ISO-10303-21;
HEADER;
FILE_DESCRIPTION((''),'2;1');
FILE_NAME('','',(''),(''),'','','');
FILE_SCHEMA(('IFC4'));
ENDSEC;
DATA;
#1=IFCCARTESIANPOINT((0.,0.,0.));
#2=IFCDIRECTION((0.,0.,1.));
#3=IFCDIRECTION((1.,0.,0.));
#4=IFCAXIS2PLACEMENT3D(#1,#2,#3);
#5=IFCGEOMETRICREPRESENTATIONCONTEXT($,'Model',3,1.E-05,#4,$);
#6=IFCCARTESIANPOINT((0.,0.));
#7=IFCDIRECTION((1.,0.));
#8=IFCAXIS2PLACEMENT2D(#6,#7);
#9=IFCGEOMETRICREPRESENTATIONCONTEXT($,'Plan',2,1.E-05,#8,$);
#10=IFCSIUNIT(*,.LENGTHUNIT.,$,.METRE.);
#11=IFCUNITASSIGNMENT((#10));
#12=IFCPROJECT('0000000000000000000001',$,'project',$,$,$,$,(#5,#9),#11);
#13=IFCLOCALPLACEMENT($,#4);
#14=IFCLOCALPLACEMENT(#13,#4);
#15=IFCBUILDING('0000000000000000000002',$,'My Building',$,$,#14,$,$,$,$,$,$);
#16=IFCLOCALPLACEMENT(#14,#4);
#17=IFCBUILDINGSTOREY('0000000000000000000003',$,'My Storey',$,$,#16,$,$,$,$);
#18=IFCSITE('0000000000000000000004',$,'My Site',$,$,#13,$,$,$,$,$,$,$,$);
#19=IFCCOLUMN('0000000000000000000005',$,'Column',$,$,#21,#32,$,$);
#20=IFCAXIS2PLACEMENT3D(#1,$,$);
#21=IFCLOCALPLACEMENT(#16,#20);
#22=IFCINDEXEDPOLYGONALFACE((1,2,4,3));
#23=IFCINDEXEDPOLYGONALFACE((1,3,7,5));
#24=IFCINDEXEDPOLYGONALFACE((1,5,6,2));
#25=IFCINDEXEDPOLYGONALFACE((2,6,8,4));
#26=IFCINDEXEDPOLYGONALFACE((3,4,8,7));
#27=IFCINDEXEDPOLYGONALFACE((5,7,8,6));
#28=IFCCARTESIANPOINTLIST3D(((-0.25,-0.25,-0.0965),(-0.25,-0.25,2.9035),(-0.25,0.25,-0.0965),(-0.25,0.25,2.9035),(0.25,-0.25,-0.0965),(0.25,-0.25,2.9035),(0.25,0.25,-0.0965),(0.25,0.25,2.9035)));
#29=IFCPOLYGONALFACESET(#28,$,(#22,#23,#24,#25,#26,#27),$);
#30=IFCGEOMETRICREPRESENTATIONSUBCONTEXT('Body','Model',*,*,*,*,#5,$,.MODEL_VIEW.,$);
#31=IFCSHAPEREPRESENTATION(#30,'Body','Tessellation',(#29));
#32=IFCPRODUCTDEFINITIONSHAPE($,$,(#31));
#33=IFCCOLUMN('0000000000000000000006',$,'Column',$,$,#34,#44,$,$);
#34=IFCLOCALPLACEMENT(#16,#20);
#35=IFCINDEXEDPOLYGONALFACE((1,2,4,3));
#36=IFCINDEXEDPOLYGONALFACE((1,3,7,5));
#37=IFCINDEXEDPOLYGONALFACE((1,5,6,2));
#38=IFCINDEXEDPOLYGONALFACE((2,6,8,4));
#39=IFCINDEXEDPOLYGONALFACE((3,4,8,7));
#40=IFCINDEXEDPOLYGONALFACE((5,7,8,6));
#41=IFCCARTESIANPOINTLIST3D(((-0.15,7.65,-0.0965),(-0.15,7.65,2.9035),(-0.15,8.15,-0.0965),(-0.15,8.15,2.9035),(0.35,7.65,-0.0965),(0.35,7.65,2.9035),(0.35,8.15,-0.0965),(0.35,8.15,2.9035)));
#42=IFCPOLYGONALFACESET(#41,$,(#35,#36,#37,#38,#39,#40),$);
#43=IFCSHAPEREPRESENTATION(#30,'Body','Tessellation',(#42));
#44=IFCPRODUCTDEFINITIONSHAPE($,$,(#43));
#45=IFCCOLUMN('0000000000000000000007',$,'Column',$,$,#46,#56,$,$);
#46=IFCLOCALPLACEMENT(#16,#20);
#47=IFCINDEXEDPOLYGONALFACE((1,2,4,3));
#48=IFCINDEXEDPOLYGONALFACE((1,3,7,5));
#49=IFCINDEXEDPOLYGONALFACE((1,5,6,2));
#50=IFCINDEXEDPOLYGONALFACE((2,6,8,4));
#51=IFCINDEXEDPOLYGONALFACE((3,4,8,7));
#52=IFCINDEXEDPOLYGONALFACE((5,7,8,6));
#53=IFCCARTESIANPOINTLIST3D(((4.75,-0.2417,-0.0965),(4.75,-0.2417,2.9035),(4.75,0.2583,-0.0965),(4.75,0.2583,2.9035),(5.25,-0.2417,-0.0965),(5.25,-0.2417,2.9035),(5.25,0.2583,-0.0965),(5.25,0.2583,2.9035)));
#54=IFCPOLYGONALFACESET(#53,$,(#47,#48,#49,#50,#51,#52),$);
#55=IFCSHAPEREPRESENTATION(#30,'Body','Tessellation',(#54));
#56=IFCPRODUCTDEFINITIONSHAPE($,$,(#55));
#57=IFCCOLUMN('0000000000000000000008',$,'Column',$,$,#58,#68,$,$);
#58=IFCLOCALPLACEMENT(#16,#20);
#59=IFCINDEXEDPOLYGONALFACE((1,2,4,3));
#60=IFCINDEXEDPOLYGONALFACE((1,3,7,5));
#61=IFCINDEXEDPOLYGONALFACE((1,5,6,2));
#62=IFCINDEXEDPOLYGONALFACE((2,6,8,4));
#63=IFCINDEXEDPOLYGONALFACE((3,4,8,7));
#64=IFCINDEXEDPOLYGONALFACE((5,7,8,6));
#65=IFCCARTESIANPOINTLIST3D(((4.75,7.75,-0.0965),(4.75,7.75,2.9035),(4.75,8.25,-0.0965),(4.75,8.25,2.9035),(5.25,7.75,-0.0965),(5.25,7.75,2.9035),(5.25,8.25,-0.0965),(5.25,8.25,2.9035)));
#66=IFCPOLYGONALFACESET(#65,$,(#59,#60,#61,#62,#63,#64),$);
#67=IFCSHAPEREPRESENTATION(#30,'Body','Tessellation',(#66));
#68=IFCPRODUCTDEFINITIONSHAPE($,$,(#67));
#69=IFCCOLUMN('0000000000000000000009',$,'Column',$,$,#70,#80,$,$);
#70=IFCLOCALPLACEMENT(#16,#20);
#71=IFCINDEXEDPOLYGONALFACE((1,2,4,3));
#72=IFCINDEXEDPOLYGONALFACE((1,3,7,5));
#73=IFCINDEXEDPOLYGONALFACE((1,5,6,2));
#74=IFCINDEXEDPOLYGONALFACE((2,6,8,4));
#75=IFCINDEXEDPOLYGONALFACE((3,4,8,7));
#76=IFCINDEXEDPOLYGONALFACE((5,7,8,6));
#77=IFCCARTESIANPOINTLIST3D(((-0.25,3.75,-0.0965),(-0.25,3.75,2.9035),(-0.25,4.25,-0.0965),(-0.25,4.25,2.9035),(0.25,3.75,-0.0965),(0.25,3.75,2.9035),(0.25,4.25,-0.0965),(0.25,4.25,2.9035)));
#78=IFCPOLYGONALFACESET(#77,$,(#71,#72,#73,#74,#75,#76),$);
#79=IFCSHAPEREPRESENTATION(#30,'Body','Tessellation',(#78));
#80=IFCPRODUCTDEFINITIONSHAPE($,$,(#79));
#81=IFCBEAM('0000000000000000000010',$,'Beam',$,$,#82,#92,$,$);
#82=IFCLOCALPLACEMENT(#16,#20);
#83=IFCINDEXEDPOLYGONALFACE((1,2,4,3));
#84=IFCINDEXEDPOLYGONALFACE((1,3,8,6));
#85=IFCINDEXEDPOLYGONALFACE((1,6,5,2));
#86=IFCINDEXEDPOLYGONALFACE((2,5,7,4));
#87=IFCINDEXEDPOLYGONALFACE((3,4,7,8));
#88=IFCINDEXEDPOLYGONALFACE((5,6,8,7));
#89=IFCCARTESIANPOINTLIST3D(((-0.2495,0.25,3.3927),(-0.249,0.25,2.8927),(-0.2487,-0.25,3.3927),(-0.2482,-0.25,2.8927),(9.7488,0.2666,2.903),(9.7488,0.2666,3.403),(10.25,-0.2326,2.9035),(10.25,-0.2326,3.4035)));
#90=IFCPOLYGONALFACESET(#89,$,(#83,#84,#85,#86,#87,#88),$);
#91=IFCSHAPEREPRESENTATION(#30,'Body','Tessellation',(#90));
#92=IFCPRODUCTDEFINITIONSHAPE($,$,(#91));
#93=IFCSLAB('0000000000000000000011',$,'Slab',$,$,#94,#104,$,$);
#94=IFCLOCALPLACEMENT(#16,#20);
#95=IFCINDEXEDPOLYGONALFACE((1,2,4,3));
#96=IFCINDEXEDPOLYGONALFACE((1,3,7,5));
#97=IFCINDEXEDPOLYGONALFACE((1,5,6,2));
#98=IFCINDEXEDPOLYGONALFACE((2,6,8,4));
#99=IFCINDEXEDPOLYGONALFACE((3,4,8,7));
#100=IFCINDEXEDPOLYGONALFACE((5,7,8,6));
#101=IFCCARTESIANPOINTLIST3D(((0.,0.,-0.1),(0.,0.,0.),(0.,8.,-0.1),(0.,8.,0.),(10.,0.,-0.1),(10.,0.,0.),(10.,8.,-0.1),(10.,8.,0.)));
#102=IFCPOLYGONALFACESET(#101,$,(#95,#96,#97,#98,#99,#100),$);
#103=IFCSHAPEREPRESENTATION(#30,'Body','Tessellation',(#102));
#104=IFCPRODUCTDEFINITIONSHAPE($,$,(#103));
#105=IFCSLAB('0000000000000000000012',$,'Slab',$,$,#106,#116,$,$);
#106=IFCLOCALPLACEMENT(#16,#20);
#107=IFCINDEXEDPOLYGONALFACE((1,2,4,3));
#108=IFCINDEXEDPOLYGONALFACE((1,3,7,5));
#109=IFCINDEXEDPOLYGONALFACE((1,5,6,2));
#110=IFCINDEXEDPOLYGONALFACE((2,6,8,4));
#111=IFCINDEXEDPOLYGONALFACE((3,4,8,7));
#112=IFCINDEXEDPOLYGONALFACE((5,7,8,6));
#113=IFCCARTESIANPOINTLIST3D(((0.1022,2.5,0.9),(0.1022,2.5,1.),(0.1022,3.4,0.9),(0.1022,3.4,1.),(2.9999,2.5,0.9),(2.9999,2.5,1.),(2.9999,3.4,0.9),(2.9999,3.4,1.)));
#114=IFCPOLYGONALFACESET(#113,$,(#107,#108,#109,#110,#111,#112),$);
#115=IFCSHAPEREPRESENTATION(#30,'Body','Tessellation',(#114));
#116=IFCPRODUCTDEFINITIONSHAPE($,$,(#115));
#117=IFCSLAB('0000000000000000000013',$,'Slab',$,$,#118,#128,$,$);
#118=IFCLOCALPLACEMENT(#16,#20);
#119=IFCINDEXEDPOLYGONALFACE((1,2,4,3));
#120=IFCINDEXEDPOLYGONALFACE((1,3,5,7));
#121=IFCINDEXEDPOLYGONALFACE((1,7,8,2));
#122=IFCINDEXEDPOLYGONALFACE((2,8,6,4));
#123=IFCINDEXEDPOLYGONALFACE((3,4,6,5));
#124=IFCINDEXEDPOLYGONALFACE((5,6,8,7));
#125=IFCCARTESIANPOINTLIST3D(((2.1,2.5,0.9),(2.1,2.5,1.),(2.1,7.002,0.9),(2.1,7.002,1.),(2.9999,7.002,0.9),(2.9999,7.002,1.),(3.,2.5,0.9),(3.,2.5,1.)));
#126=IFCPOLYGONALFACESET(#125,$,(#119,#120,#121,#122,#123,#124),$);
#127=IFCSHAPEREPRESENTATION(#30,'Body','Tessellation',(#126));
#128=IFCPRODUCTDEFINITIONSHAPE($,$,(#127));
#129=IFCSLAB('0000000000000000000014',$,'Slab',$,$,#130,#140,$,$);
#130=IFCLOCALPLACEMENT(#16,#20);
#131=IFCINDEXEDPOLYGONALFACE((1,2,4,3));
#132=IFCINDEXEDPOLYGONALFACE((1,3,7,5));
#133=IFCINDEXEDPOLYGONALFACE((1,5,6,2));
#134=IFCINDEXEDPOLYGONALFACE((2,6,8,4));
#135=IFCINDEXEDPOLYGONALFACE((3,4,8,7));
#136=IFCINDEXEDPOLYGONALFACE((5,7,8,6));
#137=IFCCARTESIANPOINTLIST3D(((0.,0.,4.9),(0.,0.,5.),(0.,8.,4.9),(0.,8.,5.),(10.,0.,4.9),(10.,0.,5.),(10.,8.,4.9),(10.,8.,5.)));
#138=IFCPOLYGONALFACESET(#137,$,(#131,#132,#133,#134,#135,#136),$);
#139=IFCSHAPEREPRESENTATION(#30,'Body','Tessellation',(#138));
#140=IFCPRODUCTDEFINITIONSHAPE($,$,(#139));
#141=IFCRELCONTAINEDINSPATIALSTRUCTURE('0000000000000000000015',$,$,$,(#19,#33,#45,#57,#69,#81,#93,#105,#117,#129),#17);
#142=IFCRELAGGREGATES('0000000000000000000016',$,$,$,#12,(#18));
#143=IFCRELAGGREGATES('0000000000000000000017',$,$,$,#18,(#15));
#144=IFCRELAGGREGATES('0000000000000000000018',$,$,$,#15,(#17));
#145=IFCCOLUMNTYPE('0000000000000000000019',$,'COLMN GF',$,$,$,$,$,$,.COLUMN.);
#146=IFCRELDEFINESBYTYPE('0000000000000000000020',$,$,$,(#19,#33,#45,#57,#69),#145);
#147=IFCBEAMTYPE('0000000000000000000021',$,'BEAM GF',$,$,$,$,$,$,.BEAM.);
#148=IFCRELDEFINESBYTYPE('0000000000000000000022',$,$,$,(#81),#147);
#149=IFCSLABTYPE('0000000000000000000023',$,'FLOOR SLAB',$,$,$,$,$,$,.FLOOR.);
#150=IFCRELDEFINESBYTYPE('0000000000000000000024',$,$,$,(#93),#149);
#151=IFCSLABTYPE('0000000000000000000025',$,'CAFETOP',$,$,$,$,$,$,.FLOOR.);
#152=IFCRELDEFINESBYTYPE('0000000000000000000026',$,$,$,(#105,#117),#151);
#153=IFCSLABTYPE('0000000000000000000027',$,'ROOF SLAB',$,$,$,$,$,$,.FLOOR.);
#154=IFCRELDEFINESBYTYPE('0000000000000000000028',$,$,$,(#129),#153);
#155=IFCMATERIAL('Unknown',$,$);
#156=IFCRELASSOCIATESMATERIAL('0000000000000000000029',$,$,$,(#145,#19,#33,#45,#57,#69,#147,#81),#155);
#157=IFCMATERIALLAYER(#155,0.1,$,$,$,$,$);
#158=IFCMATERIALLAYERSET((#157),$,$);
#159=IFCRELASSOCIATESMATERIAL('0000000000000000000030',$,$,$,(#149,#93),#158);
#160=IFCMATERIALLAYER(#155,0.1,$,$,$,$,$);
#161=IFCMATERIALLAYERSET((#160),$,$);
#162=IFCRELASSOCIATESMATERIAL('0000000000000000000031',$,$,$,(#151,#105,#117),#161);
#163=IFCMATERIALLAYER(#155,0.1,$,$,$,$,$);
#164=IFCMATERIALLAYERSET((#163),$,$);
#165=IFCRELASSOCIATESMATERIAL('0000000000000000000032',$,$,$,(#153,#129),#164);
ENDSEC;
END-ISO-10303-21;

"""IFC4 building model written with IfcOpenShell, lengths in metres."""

from ifc_helpers import new_model, si_unit, frame, origin_with_axes, origin_2d_with_axis, place, context, subcontext, project, spatial, indexed_curve, rectangle, outline, extrude, clip, halfspace, material, layer, layer_set, layer_usage, material_profile, profile_set, profile_usage, type_object, element, save


model = new_model("IFC4")

# Units and contexts
model_context = context("Model", 3, precision=1e-05, world=origin_with_axes())
plan_context = context("Plan", 2, precision=1e-05, world=origin_2d_with_axis())
body_context_1 = subcontext(model_context, "Body", "Model", "MODEL_VIEW")
ifc_project = project(units=[si_unit("LENGTHUNIT", "METRE")], contexts=[model_context, plan_context])

# Site, building, storey
site_placement = place(None, origin_with_axes())
site = spatial("IfcSite", under=ifc_project, at=site_placement, Name="My Site")
building_placement = place(site_placement, origin_with_axes())
building = spatial("IfcBuilding", under=site, at=building_placement, Name="My Building")
storey_placement = place(building_placement, origin_with_axes())
storey = spatial("IfcBuildingStorey", under=building, at=storey_placement, Name="My Storey")

# Columns
ifc_material = material(Name="Unknown")
ifc_material_profile_1 = material_profile(ifc_material, rectangle(XDim=0.5, YDim=0.5))
ifc_profile_set_1 = profile_set([ifc_material_profile_1])
ifc_profile_usage_1 = profile_usage(ifc_profile_set_1, cardinal=5)
column_type = type_object("IfcColumnType", Name="COLMN GF", PredefinedType="COLUMN", material=ifc_profile_set_1)
column_1_placement = place(storey_placement, frame((0.0, 0.0, -0.0965), z_axis=(0.0, 0.0, 1.0), x_axis=(1.0, 0.0, 0.0)))
element("IfcColumn", 1, at=column_1_placement, inside=storey, type_object=column_type, material=ifc_profile_usage_1, Name="Column", context=body_context_1, shape_type="SweptSolid", body=[
    extrude(rectangle(XDim=0.5, YDim=0.5), origin_with_axes(), (0.0, 0.0, 1.0), 3.0),
])
ifc_profile_usage_2 = profile_usage(ifc_profile_set_1, cardinal=5)
column_2_placement = place(storey_placement, frame((0.1, 7.9, -0.0965), z_axis=(0.0, 0.0, 1.0), x_axis=(1.0, 0.0, 0.0)))
element("IfcColumn", 2, at=column_2_placement, inside=storey, type_object=column_type, material=ifc_profile_usage_2, Name="Column", context=body_context_1, shape_type="SweptSolid", body=[
    extrude(rectangle(XDim=0.5, YDim=0.5), origin_with_axes(), (0.0, 0.0, 1.0), 3.0),
])
ifc_profile_usage_3 = profile_usage(ifc_profile_set_1, cardinal=5)
column_3_placement = place(storey_placement, frame((5.0, 0.0083, -0.0965), z_axis=(0.0, 0.0, 1.0), x_axis=(1.0, 0.0, 0.0)))
element("IfcColumn", 3, at=column_3_placement, inside=storey, type_object=column_type, material=ifc_profile_usage_3, Name="Column", context=body_context_1, shape_type="SweptSolid", body=[
    extrude(rectangle(XDim=0.5, YDim=0.5), origin_with_axes(), (0.0, 0.0, 1.0), 3.0),
])
ifc_profile_usage_4 = profile_usage(ifc_profile_set_1, cardinal=5)
column_4_placement = place(storey_placement, frame((5.0, 8.0, -0.0965), z_axis=(0.0, 0.0, 1.0), x_axis=(1.0, 0.0, 0.0)))
element("IfcColumn", 4, at=column_4_placement, inside=storey, type_object=column_type, material=ifc_profile_usage_4, Name="Column", context=body_context_1, shape_type="SweptSolid", body=[
    extrude(rectangle(XDim=0.5, YDim=0.5), origin_with_axes(), (0.0, 0.0, 1.0), 3.0),
])
ifc_profile_usage_5 = profile_usage(ifc_profile_set_1, cardinal=5)
column_5_placement = place(storey_placement, frame((0.0, 4.0, -0.0965), z_axis=(0.0, 0.0, 1.0), x_axis=(1.0, 0.0, 0.0)))
element("IfcColumn", 5, at=column_5_placement, inside=storey, type_object=column_type, material=ifc_profile_usage_5, Name="Column", context=body_context_1, shape_type="SweptSolid", body=[
    extrude(rectangle(XDim=0.5, YDim=0.5), origin_with_axes(), (0.0, 0.0, 1.0), 3.0),
])

# Beam
ifc_material_profile_2 = material_profile(ifc_material, rectangle(XDim=0.5, YDim=0.5))
ifc_profile_set_2 = profile_set([ifc_material_profile_2])
ifc_profile_usage_6 = profile_usage(ifc_profile_set_2, cardinal=3)
beam_type = type_object("IfcBeamType", Name="BEAM GF", PredefinedType="BEAM", material=ifc_profile_set_2)
beam_1_placement = place(storey_placement, frame((-0.2482, -0.25, 2.8927), z_axis=(0.999998, 0.001658, 0.00103), x_axis=(-0.001658, 0.999999, 0.0)))
element("IfcBeam", 6, at=beam_1_placement, inside=storey, type_object=beam_type, material=ifc_profile_usage_6, Name="Beam", context=body_context_1, shape_type="Clipping", body=[
    clip(extrude(rectangle(XDim=0.5, YDim=0.5), frame((0.25, 0.25, 0.0), z_axis=(0.0, 0.0, 1.0), x_axis=(1.0, 0.0, 0.0)), (0.0, 0.0, 1.0), 10.9982), halfspace(frame((0.0, -3.0, 10.4951), z_axis=(0.707371, -0.000728, 0.706842), x_axis=(-0.001029, -0.999999, 0.0)), False)),
])

# Slabs
ifc_layer_1 = layer(ifc_material, 0.1)
ifc_layer_set_1 = layer_set([ifc_layer_1])
ifc_layer_usage_1 = layer_usage(ifc_layer_set_1, "AXIS3", "POSITIVE", -0.1)
slab_type_1 = type_object("IfcSlabType", Name="FLOOR SLAB", PredefinedType="FLOOR", material=ifc_layer_set_1)
slab_1_placement = place(storey_placement, origin_with_axes())
element("IfcSlab", 7, at=slab_1_placement, inside=storey, type_object=slab_type_1, material=ifc_layer_usage_1, Name="Slab", context=body_context_1, shape_type="SweptSolid", body=[
    extrude(outline(indexed_curve([(0.0, 0.0), (10.0, 0.0), (10.0, 8.0), (0.0, 8.0), (0.0, 0.0)])), frame((0.0, 0.0, -0.1), z_axis=(0.0, 0.0, 1.0), x_axis=(1.0, 0.0, 0.0)), (0.0, 0.0, 1.0), 0.1),
])
ifc_layer_2 = layer(ifc_material, 0.1)
ifc_layer_set_2 = layer_set([ifc_layer_2])
ifc_layer_usage_2 = layer_usage(ifc_layer_set_2, "AXIS3", "POSITIVE", -0.1)
slab_type_2 = type_object("IfcSlabType", Name="CAFETOP", PredefinedType="FLOOR", material=ifc_layer_set_2)
slab_2_placement = place(storey_placement, frame((0.1022, 2.5, 1.0), z_axis=(0.0, 0.0, 1.0), x_axis=(1.0, 0.0, 0.0)))
element("IfcSlab", 8, at=slab_2_placement, inside=storey, type_object=slab_type_2, material=ifc_layer_usage_2, Name="Slab", context=body_context_1, shape_type="SweptSolid", body=[
    extrude(outline(indexed_curve([(0.0, 0.0), (0.0, 0.9), (2.8977, 0.9), (2.8977, 0.0), (0.0, 0.0)])), frame((0.0, 0.0, -0.1), z_axis=(0.0, 0.0, 1.0), x_axis=(1.0, 0.0, 0.0)), (0.0, 0.0, 1.0), 0.1),
])
ifc_layer_usage_3 = layer_usage(ifc_layer_set_2, "AXIS3", "POSITIVE", -0.1)
slab_3_placement = place(storey_placement, frame((3.0, 2.5, 1.0), z_axis=(0.0, 0.0, 1.0), x_axis=(1.0, 0.0, 0.0)))
element("IfcSlab", 9, at=slab_3_placement, inside=storey, type_object=slab_type_2, material=ifc_layer_usage_3, Name="Slab", context=body_context_1, shape_type="SweptSolid", body=[
    extrude(outline(indexed_curve([(0.0, 0.0), (-0.9, 0.0), (-0.9, 4.502), (-0.0001, 4.502), (0.0, 0.0)])), frame((0.0, 0.0, -0.1), z_axis=(0.0, 0.0, 1.0), x_axis=(1.0, 0.0, 0.0)), (0.0, 0.0, 1.0), 0.1),
])
ifc_layer_3 = layer(ifc_material, 0.1)
ifc_layer_set_3 = layer_set([ifc_layer_3])
ifc_layer_usage_4 = layer_usage(ifc_layer_set_3, "AXIS3", "POSITIVE", -0.1)
slab_type_3 = type_object("IfcSlabType", Name="ROOF SLAB", PredefinedType="FLOOR", material=ifc_layer_set_3)
slab_4_placement = place(storey_placement, frame((0.0, 8.0, 5.0), z_axis=(0.0, 0.0, 1.0), x_axis=(1.0, 0.0, 0.0)))
element("IfcSlab", 10, at=slab_4_placement, inside=storey, type_object=slab_type_3, material=ifc_layer_usage_4, Name="Slab", context=body_context_1, shape_type="SweptSolid", body=[
    extrude(outline(indexed_curve([(0.0, 0.0), (10.0, 0.0), (10.0, -8.0), (0.0, -8.0), (0.0, 0.0)])), frame((0.0, 0.0, -0.1), z_axis=(0.0, 0.0, 1.0), x_axis=(1.0, 0.0, 0.0)), (0.0, 0.0, 1.0), 0.1),
])

save(model, "model.ifc")
